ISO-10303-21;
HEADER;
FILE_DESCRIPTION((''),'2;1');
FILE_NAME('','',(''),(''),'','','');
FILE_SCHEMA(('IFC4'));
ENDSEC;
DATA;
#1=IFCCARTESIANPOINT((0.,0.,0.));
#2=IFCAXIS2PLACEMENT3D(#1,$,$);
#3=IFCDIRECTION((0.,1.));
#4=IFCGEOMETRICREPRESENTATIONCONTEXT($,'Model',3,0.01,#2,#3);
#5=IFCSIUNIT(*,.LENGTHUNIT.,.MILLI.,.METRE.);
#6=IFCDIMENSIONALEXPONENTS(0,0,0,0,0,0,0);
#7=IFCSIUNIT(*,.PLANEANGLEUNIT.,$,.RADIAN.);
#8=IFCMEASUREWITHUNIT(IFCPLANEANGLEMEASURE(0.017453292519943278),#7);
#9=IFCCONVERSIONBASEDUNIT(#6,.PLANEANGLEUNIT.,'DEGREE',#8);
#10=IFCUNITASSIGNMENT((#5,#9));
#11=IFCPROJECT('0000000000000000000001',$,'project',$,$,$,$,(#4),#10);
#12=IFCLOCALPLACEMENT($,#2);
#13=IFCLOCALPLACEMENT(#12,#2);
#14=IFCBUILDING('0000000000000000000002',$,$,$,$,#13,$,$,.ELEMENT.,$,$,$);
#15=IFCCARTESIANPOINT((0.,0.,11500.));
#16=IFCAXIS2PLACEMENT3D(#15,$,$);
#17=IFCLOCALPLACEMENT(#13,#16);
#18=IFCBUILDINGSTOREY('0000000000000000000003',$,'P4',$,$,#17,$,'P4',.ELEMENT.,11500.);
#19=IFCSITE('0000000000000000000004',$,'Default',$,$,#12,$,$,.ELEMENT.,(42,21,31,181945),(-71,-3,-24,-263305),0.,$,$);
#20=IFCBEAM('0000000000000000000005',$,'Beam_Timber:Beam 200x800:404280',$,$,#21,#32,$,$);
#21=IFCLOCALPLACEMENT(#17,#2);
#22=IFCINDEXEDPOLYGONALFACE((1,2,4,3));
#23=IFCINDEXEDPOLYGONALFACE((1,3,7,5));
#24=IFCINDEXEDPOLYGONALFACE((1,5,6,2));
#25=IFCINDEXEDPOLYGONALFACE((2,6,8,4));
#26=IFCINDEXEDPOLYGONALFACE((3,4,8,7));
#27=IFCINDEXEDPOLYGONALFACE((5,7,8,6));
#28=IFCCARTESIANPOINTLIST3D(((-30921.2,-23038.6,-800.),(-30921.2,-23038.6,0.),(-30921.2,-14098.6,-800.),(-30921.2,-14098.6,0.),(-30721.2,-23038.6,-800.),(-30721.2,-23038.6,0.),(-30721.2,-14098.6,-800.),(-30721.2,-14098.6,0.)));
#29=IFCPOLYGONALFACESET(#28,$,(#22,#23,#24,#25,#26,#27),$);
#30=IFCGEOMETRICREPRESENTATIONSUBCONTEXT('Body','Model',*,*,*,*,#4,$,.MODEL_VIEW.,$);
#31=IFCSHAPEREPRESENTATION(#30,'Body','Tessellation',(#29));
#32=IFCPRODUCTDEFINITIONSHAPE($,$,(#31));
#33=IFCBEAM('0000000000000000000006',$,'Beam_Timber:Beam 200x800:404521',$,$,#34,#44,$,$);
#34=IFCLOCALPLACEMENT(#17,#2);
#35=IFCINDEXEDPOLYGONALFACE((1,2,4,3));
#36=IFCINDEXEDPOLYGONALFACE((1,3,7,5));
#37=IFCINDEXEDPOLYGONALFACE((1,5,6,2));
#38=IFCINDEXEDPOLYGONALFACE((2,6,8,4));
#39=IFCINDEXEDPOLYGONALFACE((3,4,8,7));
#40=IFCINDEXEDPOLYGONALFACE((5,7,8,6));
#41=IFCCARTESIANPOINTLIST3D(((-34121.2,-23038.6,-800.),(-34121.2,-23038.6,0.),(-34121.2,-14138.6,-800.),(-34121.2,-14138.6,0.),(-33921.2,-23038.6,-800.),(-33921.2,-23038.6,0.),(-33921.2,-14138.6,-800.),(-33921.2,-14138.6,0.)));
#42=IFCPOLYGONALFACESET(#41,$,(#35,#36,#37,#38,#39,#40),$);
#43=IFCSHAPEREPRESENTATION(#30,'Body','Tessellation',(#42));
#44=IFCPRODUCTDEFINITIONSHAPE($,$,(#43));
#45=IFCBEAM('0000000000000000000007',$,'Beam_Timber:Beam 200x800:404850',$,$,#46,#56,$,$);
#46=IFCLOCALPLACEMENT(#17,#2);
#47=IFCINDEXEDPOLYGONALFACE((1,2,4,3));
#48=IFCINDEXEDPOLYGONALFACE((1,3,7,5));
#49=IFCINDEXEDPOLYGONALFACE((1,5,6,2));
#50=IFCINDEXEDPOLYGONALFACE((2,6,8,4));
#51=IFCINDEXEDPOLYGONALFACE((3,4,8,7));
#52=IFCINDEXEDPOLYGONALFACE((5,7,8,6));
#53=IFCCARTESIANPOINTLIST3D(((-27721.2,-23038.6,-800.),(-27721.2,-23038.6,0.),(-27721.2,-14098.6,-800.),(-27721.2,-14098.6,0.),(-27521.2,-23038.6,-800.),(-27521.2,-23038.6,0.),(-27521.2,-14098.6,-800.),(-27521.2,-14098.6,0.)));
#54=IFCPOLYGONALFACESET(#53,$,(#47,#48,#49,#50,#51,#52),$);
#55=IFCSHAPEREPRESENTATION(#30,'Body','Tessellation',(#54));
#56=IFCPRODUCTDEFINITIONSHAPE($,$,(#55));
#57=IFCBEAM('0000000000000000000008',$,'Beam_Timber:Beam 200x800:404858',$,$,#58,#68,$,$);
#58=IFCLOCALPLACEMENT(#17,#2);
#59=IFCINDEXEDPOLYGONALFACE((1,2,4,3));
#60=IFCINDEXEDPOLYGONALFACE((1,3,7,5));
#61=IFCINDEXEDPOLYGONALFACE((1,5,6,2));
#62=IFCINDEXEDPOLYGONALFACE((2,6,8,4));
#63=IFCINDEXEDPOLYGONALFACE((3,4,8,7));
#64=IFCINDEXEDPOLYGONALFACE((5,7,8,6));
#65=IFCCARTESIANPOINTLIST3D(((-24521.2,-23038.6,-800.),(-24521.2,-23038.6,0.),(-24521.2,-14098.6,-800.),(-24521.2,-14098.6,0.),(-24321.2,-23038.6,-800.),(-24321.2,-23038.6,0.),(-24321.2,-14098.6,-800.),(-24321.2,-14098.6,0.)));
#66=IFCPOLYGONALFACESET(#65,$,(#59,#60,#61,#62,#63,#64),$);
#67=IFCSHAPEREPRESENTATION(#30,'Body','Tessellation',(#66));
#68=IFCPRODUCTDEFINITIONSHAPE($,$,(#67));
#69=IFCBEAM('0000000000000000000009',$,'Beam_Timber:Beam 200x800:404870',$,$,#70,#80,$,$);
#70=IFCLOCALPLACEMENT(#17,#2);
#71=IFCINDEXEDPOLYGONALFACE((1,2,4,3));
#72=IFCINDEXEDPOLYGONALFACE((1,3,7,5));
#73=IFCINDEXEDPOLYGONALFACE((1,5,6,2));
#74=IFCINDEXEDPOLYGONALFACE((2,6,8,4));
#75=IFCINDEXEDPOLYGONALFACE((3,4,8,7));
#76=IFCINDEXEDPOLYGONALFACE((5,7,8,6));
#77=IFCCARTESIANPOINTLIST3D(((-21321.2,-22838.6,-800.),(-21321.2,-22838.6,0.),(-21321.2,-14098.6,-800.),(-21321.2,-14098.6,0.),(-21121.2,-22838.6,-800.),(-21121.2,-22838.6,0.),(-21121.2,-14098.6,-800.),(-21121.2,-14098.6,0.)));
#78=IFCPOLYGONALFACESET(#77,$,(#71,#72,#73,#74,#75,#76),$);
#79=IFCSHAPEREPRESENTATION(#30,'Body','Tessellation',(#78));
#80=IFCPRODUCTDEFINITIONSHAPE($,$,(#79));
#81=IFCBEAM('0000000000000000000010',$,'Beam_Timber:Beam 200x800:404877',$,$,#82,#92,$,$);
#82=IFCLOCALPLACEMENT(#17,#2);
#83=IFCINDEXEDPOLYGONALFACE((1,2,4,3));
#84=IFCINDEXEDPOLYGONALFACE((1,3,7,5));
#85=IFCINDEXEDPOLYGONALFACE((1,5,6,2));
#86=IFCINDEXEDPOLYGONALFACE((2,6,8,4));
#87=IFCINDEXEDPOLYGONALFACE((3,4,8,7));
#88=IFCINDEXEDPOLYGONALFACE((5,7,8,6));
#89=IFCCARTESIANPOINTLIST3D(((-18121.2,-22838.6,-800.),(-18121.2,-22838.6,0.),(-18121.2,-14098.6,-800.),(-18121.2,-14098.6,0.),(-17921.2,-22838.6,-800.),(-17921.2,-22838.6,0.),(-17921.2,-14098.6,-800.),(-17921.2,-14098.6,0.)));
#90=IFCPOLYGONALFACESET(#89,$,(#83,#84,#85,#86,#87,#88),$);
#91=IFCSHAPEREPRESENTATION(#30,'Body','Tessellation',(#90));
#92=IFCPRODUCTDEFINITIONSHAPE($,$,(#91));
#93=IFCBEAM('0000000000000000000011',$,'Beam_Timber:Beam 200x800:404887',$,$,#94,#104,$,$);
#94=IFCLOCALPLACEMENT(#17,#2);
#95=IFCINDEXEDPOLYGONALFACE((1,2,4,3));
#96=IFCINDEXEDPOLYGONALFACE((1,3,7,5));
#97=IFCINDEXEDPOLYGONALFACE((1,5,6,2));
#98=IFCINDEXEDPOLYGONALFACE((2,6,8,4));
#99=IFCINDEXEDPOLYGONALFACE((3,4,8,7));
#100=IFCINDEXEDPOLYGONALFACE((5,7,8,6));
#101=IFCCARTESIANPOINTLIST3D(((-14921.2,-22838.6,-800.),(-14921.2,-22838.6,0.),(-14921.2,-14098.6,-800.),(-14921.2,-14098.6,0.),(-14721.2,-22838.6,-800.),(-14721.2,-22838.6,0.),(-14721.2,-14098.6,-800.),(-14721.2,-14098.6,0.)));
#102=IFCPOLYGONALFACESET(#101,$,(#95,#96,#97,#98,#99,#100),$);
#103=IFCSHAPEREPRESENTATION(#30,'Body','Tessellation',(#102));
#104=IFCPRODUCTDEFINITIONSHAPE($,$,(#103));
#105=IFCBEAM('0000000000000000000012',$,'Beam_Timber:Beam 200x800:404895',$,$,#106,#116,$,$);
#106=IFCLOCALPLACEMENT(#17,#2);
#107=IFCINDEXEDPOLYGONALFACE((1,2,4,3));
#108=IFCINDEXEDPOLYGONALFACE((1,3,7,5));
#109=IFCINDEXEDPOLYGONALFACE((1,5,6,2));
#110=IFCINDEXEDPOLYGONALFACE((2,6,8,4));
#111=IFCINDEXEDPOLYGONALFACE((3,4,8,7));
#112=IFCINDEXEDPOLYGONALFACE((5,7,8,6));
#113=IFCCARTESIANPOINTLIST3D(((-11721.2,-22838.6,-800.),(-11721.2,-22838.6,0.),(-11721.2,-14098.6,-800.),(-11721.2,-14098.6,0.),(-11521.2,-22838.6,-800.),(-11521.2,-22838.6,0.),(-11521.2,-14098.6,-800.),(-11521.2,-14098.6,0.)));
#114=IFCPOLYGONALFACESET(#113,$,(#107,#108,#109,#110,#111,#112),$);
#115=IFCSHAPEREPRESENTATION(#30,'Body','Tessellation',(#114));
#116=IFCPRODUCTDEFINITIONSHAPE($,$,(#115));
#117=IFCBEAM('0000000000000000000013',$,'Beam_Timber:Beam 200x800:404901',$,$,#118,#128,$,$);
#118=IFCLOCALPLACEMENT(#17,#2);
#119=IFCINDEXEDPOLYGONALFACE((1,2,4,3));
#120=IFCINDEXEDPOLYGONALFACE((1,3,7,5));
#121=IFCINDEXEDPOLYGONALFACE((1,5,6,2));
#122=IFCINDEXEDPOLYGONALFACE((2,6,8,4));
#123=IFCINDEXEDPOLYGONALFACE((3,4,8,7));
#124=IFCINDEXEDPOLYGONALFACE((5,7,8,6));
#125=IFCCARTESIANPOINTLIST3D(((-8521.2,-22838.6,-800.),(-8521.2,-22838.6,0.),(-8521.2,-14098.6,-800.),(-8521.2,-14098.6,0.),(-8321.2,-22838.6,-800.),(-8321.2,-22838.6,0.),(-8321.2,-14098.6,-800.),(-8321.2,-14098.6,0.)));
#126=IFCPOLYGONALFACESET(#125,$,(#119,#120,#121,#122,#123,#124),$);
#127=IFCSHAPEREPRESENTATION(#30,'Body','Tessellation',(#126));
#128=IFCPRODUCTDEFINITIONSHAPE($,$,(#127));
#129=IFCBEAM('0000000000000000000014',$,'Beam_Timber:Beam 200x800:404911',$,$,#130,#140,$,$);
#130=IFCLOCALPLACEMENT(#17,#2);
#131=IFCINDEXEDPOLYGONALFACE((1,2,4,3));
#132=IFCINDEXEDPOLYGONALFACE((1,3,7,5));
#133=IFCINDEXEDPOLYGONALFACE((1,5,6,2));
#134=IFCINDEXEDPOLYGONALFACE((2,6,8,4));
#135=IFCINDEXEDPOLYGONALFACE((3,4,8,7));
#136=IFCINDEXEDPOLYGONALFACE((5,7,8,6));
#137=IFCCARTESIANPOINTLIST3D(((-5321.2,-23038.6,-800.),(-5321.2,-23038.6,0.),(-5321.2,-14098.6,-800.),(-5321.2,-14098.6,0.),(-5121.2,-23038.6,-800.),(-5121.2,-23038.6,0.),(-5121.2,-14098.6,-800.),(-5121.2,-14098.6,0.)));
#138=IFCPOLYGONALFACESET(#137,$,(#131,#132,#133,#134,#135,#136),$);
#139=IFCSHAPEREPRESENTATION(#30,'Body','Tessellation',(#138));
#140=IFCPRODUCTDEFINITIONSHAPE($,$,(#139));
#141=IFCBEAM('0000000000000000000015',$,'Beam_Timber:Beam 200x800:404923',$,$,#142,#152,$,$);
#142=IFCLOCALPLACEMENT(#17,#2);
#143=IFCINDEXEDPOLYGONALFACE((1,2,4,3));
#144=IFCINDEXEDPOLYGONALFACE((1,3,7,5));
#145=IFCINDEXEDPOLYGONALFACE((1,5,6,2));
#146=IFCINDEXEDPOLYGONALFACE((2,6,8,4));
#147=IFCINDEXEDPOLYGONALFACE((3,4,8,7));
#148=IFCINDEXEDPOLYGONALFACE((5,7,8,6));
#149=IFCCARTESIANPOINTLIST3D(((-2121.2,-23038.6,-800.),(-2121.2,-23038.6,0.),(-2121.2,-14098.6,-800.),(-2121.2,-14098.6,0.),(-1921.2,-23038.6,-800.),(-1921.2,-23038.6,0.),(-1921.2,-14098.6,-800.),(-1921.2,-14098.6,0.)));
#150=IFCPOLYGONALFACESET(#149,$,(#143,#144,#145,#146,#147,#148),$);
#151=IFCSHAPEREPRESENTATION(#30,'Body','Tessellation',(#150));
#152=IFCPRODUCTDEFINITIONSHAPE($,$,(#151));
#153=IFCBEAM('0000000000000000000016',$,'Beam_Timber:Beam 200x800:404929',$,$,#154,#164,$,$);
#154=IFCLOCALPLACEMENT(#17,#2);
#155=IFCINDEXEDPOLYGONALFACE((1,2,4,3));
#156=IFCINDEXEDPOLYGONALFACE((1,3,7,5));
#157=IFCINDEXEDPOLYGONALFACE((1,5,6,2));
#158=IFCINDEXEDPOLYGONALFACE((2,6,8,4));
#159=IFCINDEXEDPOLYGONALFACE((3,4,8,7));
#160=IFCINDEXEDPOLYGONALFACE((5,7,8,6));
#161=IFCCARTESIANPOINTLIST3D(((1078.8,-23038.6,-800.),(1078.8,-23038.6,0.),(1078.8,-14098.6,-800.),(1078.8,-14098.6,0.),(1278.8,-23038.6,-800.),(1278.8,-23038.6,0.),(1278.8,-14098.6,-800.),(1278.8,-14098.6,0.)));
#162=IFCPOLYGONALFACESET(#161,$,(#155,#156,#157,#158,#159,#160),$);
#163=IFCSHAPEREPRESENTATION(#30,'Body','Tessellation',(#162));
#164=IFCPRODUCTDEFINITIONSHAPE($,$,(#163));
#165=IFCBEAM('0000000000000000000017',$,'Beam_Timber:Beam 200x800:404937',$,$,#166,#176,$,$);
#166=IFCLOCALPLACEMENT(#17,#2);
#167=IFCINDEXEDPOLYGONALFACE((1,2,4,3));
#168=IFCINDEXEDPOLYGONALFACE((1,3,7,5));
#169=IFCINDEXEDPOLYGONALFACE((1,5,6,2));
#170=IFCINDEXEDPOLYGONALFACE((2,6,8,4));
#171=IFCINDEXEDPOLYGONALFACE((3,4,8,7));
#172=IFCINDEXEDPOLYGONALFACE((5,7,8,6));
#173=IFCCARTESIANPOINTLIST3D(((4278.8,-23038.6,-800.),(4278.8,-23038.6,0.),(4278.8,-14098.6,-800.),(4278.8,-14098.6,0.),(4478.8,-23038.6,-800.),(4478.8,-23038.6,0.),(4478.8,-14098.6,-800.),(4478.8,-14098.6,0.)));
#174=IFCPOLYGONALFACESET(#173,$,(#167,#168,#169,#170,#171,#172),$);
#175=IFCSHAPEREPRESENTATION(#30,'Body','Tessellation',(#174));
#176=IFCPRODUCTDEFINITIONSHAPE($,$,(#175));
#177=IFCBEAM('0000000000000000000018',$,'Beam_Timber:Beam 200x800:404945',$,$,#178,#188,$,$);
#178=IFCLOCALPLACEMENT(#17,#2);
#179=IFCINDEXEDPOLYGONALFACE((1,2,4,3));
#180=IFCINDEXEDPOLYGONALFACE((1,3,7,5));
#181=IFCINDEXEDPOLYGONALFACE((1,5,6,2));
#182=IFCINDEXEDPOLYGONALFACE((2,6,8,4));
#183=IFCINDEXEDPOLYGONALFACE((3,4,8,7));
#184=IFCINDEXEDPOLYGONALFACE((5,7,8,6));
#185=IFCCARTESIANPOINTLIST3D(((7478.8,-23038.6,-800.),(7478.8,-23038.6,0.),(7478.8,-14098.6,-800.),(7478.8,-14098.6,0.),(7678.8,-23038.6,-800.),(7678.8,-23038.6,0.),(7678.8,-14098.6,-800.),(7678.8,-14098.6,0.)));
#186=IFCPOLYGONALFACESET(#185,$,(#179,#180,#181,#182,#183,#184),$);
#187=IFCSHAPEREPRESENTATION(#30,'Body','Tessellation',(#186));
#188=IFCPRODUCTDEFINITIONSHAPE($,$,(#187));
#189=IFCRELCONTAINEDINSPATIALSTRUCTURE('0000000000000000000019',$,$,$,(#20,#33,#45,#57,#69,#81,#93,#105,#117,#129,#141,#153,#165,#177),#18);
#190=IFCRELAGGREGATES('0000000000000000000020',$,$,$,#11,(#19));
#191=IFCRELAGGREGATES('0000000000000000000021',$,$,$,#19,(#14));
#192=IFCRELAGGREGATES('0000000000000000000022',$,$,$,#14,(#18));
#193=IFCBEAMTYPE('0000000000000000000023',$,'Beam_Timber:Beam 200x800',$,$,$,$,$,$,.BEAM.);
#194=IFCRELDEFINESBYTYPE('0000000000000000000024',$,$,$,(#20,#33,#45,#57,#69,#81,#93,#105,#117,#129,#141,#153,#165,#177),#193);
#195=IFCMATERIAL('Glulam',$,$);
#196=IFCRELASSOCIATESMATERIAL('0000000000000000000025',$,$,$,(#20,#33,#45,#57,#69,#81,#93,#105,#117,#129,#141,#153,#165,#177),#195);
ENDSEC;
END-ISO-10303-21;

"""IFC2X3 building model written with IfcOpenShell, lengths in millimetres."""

from ifc_helpers import new_model, entity, si_unit, converted_unit, direction, frame, frame_2d, origin, origin_2d_with_axis, place, context, subcontext, project, spatial, rectangle, extrude, material, type_object, element, save


model = new_model("IFC2X3")

# Units and contexts
model_context = context("Model", 3, precision=0.01, world=origin(), true_north=direction((0.0, 1.0)))
body_context = subcontext(model_context, "Body", "Model", "MODEL_VIEW")
ifc_project = project(units=[si_unit("LENGTHUNIT", "METRE", prefix="MILLI"), converted_unit("PLANEANGLEUNIT", "DEGREE", entity("IfcPlaneAngleMeasure", 0.017453292519943278), si_unit("PLANEANGLEUNIT", "RADIAN"), dimensions=[0, 0, 0, 0, 0, 0, 0])], contexts=[model_context])

# Site, building, storey
site_placement = place(None, origin())
site = spatial("IfcSite", under=ifc_project, at=site_placement, Name="Default", CompositionType="ELEMENT", RefLatitude=(42, 21, 31, 181945), RefLongitude=(-71, -3, -24, -263305), RefElevation=0.0)
building_placement = place(site_placement, origin())
building = spatial("IfcBuilding", under=site, at=building_placement, CompositionType="ELEMENT")
storey_placement = place(building_placement, frame((0.0, 0.0, 11500.0)))
storey = spatial("IfcBuildingStorey", under=building, at=storey_placement, Name="P4", LongName="P4", CompositionType="ELEMENT", Elevation=11500.0)

# Shared definitions
ifc_material_1 = material(Name="Glulam")

# Beams
beam_type = type_object("IfcBeamType", Name="Beam_Timber:Beam 200x800", PredefinedType="BEAM")
beam_1_placement = place(storey_placement, frame((-30821.2, -22938.6, 0.0), z_axis=(0.0, 0.0, 1.0), x_axis=(0.0, 1.0, 0.0)))
element("IfcBeam", 1, at=beam_1_placement, inside=storey, type_object=beam_type, material=ifc_material_1, Name="Beam_Timber:Beam 200x800:404280", context=body_context, shape_type="SweptSolid", body=[
    extrude(rectangle(XDim=800.0, YDim=200.0, at=frame_2d((0.0, 0.0), x_axis=(1.0, 0.0))), frame((-100.0, 0.0, -400.0), z_axis=(1.0, 0.0, 0.0), x_axis=(0.0, 0.0, -1.0)), (0.0, 0.0, 1.0), 8940.0),
])
beam_2_placement = place(storey_placement, frame((-34021.2, -22938.6, 0.0), z_axis=(0.0, 0.0, 1.0), x_axis=(0.0, 1.0, 0.0)))
element("IfcBeam", 2, at=beam_2_placement, inside=storey, type_object=beam_type, material=ifc_material_1, Name="Beam_Timber:Beam 200x800:404521", context=body_context, shape_type="SweptSolid", body=[
    extrude(rectangle(XDim=800.0, YDim=200.0, at=frame_2d((0.0, 0.0), x_axis=(1.0, 0.0))), frame((-100.0, 0.0, -400.0), z_axis=(1.0, 0.0, 0.0), x_axis=(0.0, 0.0, -1.0)), (0.0, 0.0, 1.0), 8900.0),
])
for number, where, z_axis, x_axis, name in (
    (3, (-27621.2, -22938.6, 0.0), (0.0, 0.0, 1.0), (0.0, 1.0, 0.0), "Beam_Timber:Beam 200x800:404850"),
    (4, (-24421.2, -22938.6, 0.0), (0.0, 0.0, 1.0), (0.0, 1.0, 0.0), "Beam_Timber:Beam 200x800:404858"),
):
    element("IfcBeam", number, at=place(storey_placement, frame(where, z_axis=z_axis, x_axis=x_axis)), inside=storey, type_object=beam_type, material=ifc_material_1, Name=name, context=body_context, shape_type="SweptSolid", body=[
        extrude(rectangle(XDim=800.0, YDim=200.0, at=frame_2d((0.0, 0.0), x_axis=(1.0, 0.0))), frame((-100.0, 0.0, -400.0), z_axis=(1.0, 0.0, 0.0), x_axis=(0.0, 0.0, -1.0)), (0.0, 0.0, 1.0), 8940.0),
    ])
beam_3_placement = place(storey_placement, frame((-21221.2, -22938.6, 0.0), z_axis=(0.0, 0.0, 1.0), x_axis=(0.0, 1.0, 0.0)))
element("IfcBeam", 5, at=beam_3_placement, inside=storey, type_object=beam_type, material=ifc_material_1, Name="Beam_Timber:Beam 200x800:404870", context=body_context, shape_type="SweptSolid", body=[
    extrude(rectangle(XDim=800.0, YDim=200.0, at=frame_2d((0.0, 0.0), x_axis=(1.0, 0.0))), frame((100.0, 0.0, -400.0), z_axis=(1.0, 0.0, 0.0), x_axis=(0.0, 0.0, -1.0)), (0.0, 0.0, 1.0), 8740.0),
])
for number, where, z_axis, x_axis, name in (
    (6, (-18021.2, -22938.6, 0.0), (0.0, 0.0, 1.0), (0.0, 1.0, 0.0), "Beam_Timber:Beam 200x800:404877"),
    (7, (-14821.2, -22938.6, 0.0), (0.0, 0.0, 1.0), (0.0, 1.0, 0.0), "Beam_Timber:Beam 200x800:404887"),
    (8, (-11621.2, -22938.6, 0.0), (0.0, 0.0, 1.0), (0.0, 1.0, 0.0), "Beam_Timber:Beam 200x800:404895"),
):
    element("IfcBeam", number, at=place(storey_placement, frame(where, z_axis=z_axis, x_axis=x_axis)), inside=storey, type_object=beam_type, material=ifc_material_1, Name=name, context=body_context, shape_type="SweptSolid", body=[
        extrude(rectangle(XDim=800.0, YDim=200.0, at=frame_2d((0.0, 0.0), x_axis=(1.0, 0.0))), frame((100.0, 0.0, -400.0), z_axis=(1.0, 0.0, 0.0), x_axis=(0.0, 0.0, -1.0)), (0.0, 0.0, 1.0), 8740.0),
    ])
beam_4_placement = place(storey_placement, frame((-8421.2, -22938.6, 0.0), z_axis=(0.0, 0.0, 1.0), x_axis=(0.0, 1.0, 0.0)))
element("IfcBeam", 9, at=beam_4_placement, inside=storey, type_object=beam_type, material=ifc_material_1, Name="Beam_Timber:Beam 200x800:404901", context=body_context, shape_type="SweptSolid", body=[
    extrude(rectangle(XDim=800.0, YDim=200.0, at=frame_2d((0.0, 0.0), x_axis=(1.0, 0.0))), frame((100.0, 0.0, -400.0), z_axis=(1.0, 0.0, 0.0), x_axis=(0.0, 0.0, -1.0)), (0.0, 0.0, 1.0), 8740.0),
])
beam_5_placement = place(storey_placement, frame((-5221.2, -22938.6, 0.0), z_axis=(0.0, 0.0, 1.0), x_axis=(0.0, 1.0, 0.0)))
element("IfcBeam", 10, at=beam_5_placement, inside=storey, type_object=beam_type, material=ifc_material_1, Name="Beam_Timber:Beam 200x800:404911", context=body_context, shape_type="SweptSolid", body=[
    extrude(rectangle(XDim=800.0, YDim=200.0, at=frame_2d((0.0, 0.0), x_axis=(1.0, 0.0))), frame((-100.0, 0.0, -400.0), z_axis=(1.0, 0.0, 0.0), x_axis=(0.0, 0.0, -1.0)), (0.0, 0.0, 1.0), 8940.0),
])
beam_6_placement = place(storey_placement, frame((-2021.2, -22938.6, 0.0), z_axis=(0.0, 0.0, 1.0), x_axis=(0.0, 1.0, 0.0)))
element("IfcBeam", 11, at=beam_6_placement, inside=storey, type_object=beam_type, material=ifc_material_1, Name="Beam_Timber:Beam 200x800:404923", context=body_context, shape_type="SweptSolid", body=[
    extrude(rectangle(XDim=800.0, YDim=200.0, at=frame_2d((0.0, 0.0), x_axis=(1.0, 0.0))), frame((-100.0, 0.0, -400.0), z_axis=(1.0, 0.0, 0.0), x_axis=(0.0, 0.0, -1.0)), (0.0, 0.0, 1.0), 8940.0),
])
beam_7_placement = place(storey_placement, frame((1178.8, -22938.6, 0.0), z_axis=(0.0, 0.0, 1.0), x_axis=(0.0, 1.0, 0.0)))
element("IfcBeam", 12, at=beam_7_placement, inside=storey, type_object=beam_type, material=ifc_material_1, Name="Beam_Timber:Beam 200x800:404929", context=body_context, shape_type="SweptSolid", body=[
    extrude(rectangle(XDim=800.0, YDim=200.0, at=frame_2d((0.0, 0.0), x_axis=(1.0, 0.0))), frame((-100.0, 0.0, -400.0), z_axis=(1.0, 0.0, 0.0), x_axis=(0.0, 0.0, -1.0)), (0.0, 0.0, 1.0), 8940.0),
])
beam_8_placement = place(storey_placement, frame((4378.8, -22938.6, 0.0), z_axis=(0.0, 0.0, 1.0), x_axis=(0.0, 1.0, 0.0)))
element("IfcBeam", 13, at=beam_8_placement, inside=storey, type_object=beam_type, material=ifc_material_1, Name="Beam_Timber:Beam 200x800:404937", context=body_context, shape_type="SweptSolid", body=[
    extrude(rectangle(XDim=800.0, YDim=200.0, at=origin_2d_with_axis()), frame((-100.0, 0.0, -400.0), z_axis=(1.0, 0.0, 0.0), x_axis=(0.0, 0.0, -1.0)), (0.0, 0.0, 1.0), 8940.0),
])
beam_9_placement = place(storey_placement, frame((7578.8, -22938.6, 0.0), z_axis=(0.0, 0.0, 1.0), x_axis=(0.0, 1.0, 0.0)))
element("IfcBeam", 14, at=beam_9_placement, inside=storey, type_object=beam_type, material=ifc_material_1, Name="Beam_Timber:Beam 200x800:404945", context=body_context, shape_type="SweptSolid", body=[
    extrude(rectangle(XDim=800.0, YDim=200.0, at=frame_2d((0.0, 0.0), x_axis=(1.0, 0.0))), frame((-100.0, 0.0, -400.0), z_axis=(1.0, 0.0, 0.0), x_axis=(0.0, 0.0, -1.0)), (0.0, 0.0, 1.0), 8940.0),
])

save(model, "model.ifc")
